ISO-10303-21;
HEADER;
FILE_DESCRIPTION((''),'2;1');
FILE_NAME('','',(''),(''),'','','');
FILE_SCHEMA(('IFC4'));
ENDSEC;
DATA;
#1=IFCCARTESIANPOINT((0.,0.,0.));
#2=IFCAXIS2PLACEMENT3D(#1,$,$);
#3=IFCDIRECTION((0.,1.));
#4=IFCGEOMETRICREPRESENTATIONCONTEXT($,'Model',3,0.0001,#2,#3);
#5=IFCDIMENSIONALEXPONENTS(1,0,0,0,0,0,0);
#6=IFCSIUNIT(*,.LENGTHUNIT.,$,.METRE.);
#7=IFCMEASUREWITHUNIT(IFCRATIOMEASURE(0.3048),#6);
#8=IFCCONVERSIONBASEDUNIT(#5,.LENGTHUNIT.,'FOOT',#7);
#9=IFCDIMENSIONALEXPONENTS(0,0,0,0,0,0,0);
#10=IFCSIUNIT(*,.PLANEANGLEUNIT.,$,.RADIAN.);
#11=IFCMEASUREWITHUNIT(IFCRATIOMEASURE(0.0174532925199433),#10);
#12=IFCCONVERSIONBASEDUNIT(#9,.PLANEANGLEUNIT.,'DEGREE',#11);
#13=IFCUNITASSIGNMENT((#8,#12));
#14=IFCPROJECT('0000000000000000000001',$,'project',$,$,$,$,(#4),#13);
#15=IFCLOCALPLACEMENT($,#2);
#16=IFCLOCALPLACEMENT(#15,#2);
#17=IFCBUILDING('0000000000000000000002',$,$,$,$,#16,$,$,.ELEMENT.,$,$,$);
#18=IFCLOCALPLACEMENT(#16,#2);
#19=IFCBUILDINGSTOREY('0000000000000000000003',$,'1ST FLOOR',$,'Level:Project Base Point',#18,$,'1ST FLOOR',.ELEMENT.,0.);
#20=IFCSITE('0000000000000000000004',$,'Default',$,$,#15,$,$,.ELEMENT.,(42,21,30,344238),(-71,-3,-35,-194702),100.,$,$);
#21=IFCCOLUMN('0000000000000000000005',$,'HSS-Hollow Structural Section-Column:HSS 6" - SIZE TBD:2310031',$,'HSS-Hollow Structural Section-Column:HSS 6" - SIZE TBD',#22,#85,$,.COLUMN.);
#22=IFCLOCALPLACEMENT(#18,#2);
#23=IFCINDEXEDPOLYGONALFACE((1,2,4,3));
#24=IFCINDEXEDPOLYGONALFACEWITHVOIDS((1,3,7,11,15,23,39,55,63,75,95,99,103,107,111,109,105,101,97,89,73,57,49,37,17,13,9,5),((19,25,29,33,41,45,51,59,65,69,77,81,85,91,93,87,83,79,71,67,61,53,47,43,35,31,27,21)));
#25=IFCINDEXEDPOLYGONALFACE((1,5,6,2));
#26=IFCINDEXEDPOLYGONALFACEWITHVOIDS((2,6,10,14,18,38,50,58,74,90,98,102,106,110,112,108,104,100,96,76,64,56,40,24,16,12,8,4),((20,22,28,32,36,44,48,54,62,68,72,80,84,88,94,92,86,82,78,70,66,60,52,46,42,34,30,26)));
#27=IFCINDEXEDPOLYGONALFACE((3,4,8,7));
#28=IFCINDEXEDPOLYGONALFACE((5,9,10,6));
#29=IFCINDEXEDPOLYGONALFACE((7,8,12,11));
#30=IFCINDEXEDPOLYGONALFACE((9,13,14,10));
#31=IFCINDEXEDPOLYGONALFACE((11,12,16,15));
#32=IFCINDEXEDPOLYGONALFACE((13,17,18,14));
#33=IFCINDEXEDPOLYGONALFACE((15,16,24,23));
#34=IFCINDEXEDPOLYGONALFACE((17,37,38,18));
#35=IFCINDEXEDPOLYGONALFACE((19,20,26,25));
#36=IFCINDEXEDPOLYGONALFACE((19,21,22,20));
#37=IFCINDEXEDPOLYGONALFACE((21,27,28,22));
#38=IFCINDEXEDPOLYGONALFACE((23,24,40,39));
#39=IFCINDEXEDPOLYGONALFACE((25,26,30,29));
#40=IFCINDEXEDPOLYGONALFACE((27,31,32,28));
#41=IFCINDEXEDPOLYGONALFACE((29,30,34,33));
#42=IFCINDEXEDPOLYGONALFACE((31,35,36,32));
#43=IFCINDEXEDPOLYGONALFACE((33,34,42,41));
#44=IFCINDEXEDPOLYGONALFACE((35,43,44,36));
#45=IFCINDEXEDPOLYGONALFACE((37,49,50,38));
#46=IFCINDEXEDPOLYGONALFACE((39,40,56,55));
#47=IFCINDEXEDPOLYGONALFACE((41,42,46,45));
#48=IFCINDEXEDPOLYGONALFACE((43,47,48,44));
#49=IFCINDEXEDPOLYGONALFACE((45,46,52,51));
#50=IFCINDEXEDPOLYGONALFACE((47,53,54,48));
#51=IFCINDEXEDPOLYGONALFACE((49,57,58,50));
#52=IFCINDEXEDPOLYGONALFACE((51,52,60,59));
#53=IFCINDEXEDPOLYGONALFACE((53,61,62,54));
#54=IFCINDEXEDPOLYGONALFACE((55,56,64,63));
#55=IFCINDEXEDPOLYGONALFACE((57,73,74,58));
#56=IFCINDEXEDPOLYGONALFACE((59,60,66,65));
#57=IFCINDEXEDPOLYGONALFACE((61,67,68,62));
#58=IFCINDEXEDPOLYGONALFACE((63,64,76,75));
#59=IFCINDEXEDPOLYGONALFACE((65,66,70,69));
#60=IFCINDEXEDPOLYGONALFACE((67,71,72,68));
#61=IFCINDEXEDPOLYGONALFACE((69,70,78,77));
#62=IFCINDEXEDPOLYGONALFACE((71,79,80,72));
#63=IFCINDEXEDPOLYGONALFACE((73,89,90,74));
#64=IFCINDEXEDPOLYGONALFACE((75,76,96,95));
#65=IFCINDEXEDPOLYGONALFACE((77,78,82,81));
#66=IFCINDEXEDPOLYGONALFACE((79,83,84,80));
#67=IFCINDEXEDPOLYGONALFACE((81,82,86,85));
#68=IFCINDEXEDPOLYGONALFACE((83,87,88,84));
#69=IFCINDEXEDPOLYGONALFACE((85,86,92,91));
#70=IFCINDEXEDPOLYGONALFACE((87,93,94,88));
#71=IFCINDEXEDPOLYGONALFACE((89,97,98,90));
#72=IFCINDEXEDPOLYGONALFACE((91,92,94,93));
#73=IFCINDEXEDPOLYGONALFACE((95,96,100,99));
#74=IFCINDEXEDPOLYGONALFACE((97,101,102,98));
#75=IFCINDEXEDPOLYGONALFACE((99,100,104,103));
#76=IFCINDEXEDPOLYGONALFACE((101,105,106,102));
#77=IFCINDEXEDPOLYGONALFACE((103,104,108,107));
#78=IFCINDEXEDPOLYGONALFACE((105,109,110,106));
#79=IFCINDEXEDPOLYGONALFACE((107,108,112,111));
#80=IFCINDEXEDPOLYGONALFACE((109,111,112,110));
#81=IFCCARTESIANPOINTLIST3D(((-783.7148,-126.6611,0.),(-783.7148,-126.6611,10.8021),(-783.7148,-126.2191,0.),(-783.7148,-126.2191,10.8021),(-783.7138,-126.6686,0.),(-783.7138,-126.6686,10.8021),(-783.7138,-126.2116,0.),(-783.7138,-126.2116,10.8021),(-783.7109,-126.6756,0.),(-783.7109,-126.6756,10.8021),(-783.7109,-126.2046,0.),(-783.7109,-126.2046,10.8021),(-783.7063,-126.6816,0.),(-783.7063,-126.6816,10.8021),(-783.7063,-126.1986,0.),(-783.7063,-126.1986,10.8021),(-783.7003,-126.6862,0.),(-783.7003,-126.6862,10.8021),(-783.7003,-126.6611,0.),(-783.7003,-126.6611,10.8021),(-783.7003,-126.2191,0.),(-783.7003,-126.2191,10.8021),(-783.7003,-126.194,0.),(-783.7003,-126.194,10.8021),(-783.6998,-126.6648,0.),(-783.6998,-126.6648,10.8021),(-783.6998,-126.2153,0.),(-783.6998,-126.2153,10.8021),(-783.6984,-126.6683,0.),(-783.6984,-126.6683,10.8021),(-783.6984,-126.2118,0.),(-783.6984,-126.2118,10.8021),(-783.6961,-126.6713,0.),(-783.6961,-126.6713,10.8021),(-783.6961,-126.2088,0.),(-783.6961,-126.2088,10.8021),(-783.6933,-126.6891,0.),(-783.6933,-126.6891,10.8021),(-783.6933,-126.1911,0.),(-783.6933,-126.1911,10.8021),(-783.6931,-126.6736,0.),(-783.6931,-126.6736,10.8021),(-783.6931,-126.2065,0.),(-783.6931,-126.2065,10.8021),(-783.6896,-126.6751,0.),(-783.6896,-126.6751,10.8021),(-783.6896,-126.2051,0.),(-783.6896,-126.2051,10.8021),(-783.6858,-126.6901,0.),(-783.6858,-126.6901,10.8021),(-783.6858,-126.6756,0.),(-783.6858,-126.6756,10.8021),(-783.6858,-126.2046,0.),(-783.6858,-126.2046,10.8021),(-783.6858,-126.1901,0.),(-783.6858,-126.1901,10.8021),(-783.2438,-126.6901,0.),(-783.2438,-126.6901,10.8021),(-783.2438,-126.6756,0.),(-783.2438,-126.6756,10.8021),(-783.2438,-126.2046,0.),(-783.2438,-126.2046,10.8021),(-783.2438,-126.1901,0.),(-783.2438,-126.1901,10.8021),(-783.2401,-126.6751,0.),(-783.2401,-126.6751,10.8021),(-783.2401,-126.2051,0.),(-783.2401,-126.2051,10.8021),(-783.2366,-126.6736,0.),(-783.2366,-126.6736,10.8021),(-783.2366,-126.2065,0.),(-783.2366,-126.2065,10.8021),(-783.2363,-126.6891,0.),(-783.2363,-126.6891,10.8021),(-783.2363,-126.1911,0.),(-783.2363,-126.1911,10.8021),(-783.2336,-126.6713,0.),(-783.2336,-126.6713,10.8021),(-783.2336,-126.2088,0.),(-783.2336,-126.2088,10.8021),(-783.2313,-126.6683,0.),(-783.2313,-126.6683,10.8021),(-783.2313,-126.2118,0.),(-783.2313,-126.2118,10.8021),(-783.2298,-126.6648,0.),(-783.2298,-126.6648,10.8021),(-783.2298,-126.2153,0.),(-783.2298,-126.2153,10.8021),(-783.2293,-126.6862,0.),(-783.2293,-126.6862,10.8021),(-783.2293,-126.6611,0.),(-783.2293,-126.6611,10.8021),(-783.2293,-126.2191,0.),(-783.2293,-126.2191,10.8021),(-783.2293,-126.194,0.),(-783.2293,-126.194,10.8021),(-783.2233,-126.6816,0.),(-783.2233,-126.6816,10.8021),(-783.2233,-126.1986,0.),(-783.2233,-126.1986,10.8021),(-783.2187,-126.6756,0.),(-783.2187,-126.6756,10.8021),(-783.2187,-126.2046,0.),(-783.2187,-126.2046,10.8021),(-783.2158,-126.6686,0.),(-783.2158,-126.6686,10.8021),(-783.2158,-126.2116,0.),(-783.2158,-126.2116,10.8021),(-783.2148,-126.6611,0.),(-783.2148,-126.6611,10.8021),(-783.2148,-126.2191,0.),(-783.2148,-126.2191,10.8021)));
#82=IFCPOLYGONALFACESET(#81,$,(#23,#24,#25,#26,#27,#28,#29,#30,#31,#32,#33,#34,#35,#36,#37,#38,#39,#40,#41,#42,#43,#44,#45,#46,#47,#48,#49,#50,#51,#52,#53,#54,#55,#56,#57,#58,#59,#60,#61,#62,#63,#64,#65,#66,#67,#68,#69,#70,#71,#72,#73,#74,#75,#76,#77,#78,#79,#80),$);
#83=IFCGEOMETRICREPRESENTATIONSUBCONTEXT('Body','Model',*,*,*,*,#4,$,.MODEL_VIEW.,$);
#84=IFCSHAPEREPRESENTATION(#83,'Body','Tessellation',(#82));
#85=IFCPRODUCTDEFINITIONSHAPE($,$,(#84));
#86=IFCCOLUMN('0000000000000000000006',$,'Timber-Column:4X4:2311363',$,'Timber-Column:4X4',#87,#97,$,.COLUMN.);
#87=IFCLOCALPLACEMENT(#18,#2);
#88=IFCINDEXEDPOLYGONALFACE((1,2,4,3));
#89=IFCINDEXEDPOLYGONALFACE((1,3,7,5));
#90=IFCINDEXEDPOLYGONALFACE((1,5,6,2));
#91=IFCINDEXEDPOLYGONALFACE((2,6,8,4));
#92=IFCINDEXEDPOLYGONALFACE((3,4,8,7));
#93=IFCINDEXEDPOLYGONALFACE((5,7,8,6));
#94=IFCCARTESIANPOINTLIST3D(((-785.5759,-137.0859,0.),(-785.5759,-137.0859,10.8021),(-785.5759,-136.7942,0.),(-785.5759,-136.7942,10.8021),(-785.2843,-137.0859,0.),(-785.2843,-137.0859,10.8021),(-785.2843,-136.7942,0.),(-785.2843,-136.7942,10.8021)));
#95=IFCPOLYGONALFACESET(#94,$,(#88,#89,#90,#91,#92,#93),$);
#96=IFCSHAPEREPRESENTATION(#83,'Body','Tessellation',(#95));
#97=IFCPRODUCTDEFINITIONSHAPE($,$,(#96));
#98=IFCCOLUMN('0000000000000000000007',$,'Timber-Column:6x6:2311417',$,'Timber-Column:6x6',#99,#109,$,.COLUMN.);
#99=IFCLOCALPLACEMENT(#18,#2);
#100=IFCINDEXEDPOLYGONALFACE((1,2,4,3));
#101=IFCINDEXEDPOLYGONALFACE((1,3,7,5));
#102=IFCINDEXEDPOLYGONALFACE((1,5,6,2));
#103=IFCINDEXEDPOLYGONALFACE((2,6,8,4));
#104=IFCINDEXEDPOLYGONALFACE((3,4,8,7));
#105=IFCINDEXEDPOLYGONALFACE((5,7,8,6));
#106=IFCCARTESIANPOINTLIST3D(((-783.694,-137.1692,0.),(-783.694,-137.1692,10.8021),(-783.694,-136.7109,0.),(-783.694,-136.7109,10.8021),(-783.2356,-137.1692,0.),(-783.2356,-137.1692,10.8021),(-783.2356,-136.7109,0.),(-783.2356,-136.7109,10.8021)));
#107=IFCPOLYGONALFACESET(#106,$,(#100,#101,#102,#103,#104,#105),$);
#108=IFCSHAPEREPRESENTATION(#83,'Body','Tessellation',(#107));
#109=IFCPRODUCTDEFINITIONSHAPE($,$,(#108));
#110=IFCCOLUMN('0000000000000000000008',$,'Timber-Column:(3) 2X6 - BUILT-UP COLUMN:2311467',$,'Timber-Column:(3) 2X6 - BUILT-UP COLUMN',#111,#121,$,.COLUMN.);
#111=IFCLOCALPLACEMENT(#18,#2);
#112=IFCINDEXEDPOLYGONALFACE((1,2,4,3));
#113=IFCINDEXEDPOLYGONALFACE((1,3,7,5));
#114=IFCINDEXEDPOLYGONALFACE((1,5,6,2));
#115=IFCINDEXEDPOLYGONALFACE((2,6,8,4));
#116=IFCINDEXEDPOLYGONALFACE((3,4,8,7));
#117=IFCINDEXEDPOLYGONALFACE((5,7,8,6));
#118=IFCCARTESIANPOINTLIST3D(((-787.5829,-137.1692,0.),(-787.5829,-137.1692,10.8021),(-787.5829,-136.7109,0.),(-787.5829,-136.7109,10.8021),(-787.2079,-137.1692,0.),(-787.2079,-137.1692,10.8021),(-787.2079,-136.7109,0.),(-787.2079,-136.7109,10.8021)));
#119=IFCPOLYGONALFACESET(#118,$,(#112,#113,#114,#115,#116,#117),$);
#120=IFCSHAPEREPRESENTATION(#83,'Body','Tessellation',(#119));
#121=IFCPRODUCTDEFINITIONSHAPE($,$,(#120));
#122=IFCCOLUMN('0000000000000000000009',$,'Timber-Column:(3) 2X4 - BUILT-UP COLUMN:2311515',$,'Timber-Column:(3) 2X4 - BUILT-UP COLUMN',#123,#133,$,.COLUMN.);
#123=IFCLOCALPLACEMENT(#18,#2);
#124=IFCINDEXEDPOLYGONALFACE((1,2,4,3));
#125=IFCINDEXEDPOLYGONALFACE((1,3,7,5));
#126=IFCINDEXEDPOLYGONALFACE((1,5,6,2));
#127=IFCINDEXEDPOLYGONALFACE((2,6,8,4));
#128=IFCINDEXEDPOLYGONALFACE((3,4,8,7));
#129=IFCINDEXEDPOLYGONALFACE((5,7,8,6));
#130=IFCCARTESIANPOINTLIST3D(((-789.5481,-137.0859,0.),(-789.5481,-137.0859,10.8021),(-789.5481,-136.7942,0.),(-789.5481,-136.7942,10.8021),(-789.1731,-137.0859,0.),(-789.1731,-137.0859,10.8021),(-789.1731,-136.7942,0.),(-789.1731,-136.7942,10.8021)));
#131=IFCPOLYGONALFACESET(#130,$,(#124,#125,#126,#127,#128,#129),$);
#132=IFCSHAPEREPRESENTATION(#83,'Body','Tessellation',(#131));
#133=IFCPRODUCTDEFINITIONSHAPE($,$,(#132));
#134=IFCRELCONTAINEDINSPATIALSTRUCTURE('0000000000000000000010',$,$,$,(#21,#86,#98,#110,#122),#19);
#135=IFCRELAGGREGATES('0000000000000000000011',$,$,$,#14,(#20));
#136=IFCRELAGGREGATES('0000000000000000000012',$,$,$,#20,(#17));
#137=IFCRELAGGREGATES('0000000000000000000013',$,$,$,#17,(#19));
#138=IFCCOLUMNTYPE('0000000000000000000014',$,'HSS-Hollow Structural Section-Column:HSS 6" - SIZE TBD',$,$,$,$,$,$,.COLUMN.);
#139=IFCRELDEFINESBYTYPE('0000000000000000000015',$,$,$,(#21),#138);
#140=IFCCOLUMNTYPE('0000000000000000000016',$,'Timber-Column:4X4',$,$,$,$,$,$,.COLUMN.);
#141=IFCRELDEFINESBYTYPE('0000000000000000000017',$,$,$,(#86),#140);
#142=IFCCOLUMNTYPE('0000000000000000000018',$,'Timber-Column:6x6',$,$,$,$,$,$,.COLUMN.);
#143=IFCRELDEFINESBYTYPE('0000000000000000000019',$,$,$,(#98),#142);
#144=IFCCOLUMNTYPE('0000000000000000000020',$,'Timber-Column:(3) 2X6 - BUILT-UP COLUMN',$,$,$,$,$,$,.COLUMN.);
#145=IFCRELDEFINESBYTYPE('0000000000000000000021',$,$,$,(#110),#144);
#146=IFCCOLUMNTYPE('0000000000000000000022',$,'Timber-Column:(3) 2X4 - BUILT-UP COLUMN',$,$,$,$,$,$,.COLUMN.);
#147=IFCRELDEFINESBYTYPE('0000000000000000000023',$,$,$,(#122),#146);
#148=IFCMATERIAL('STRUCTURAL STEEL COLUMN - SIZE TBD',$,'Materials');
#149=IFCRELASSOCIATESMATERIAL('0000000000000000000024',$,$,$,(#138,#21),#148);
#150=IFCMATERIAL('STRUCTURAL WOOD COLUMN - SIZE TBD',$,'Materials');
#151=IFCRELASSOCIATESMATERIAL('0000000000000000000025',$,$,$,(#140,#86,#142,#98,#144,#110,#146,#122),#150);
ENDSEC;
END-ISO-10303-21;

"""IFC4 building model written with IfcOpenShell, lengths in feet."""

from ifc_helpers import new_model, entity, si_unit, converted_unit, direction, frame, frame_2d, origin, origin_2d_with_axis, place, context, subcontext, project, spatial, polyline, circle_curve, parameter, trimmed, segment, composite_curve, rectangle, outline, extrude, source, transform, mapped, material, material_profile, profile_set, profile_usage, type_object, type_shapes, element, save


model = new_model("IFC4")

# Units and contexts
model_context = context("Model", 3, precision=0.0001, world=origin(), true_north=direction((0.0, 1.0)))
body_context = subcontext(model_context, "Body", "Model", "MODEL_VIEW")
ifc_project = project(units=[converted_unit("LENGTHUNIT", "FOOT", entity("IfcRatioMeasure", 0.3048), si_unit("LENGTHUNIT", "METRE"), dimensions=[1, 0, 0, 0, 0, 0, 0]), converted_unit("PLANEANGLEUNIT", "DEGREE", entity("IfcRatioMeasure", 0.0174532925199433), si_unit("PLANEANGLEUNIT", "RADIAN"), dimensions=[0, 0, 0, 0, 0, 0, 0])], contexts=[model_context])

# Site, building, storey
site_placement = place(None, origin())
site = spatial("IfcSite", under=ifc_project, at=site_placement, Name="Default", CompositionType="ELEMENT", RefLatitude=(42, 21, 30, 344238), RefLongitude=(-71, -3, -35, -194702), RefElevation=100.0)
building_placement = place(site_placement, origin())
building = spatial("IfcBuilding", under=site, at=building_placement, CompositionType="ELEMENT")
storey_placement = place(building_placement, origin())
storey = spatial("IfcBuildingStorey", under=building, at=storey_placement, Name="1ST FLOOR", ObjectType="Level:Project Base Point", LongName="1ST FLOOR", CompositionType="ELEMENT", Elevation=0.0)

# Columns
ifc_material_1 = material(Name="STRUCTURAL STEEL COLUMN - SIZE TBD", Category="Materials")
ifc_material_profile_1 = material_profile(ifc_material_1, outline(composite_curve([segment(polyline([(-0.221, -0.25), (0.221, -0.25)]), True, "CONTINUOUS"), segment(trimmed(circle_curve(frame_2d((0.221, -0.221), x_axis=(-1.0, 0.0)), 0.029), [parameter(90.0)], [parameter(180.0)], True, "PARAMETER"), True, "CONTINUOUS"), segment(polyline([(0.25, -0.221), (0.25, 0.221)]), True, "CONTINUOUS"), segment(trimmed(circle_curve(frame_2d((0.221, 0.221), x_axis=(-1.0, 0.0)), 0.029), [parameter(180.0)], [parameter(270.0)], True, "PARAMETER"), True, "CONTINUOUS"), segment(polyline([(0.221, 0.25), (-0.221, 0.25)]), True, "CONTINUOUS"), segment(trimmed(circle_curve(frame_2d((-0.221, 0.221), x_axis=(-1.0, 0.0)), 0.029), [parameter(270.0)], [parameter(360.0)], True, "PARAMETER"), True, "CONTINUOUS"), segment(polyline([(-0.25, 0.221), (-0.25, -0.221)]), True, "CONTINUOUS"), segment(trimmed(circle_curve(frame_2d((-0.221, -0.221), x_axis=(-1.0, 0.0)), 0.029), [parameter(360.0)], [parameter(90.0)], True, "PARAMETER"), True, "CONTINUOUS")], self_intersect=False), holes=[composite_curve([segment(trimmed(circle_curve(frame_2d((-0.221, -0.221), x_axis=(-1.0, 0.0)), 0.0145), [parameter(0.0)], [parameter(90.0)], True, "PARAMETER"), False, "CONTINUOUS"), segment(polyline([(-0.2355, -0.221), (-0.2355, 0.221)]), True, "CONTINUOUS"), segment(trimmed(circle_curve(frame_2d((-0.221, 0.221), x_axis=(-1.0, 0.0)), 0.0145), [parameter(270.0)], [parameter(360.0)], True, "PARAMETER"), False, "CONTINUOUS"), segment(polyline([(-0.221, 0.2355), (0.221, 0.2355)]), True, "CONTINUOUS"), segment(trimmed(circle_curve(frame_2d((0.221, 0.221), x_axis=(-1.0, 0.0)), 0.0145), [parameter(180.0)], [parameter(270.0)], True, "PARAMETER"), False, "CONTINUOUS"), segment(polyline([(0.2355, 0.221), (0.2355, -0.221)]), True, "CONTINUOUS"), segment(trimmed(circle_curve(frame_2d((0.221, -0.221), x_axis=(-1.0, 0.0)), 0.0145), [parameter(90.0)], [parameter(180.0)], True, "PARAMETER"), False, "CONTINUOUS"), segment(polyline([(0.221, -0.2355), (-0.221, -0.2355)]), True, "CONTINUOUS")], self_intersect=False)]), Name="HSS 6\" - SIZE TBD")
ifc_profile_set_1 = profile_set([ifc_material_profile_1], Name="HSS 6\" - SIZE TBD")
ifc_profile_usage_1 = profile_usage(ifc_profile_set_1)
column_type_1 = type_object("IfcColumnType", Name="HSS-Hollow Structural Section-Column:HSS 6\" - SIZE TBD", PredefinedType="COLUMN", material=ifc_profile_set_1)
shared_shape_1 = source(origin(), body_context, "Body", "SweptSolid", [
    extrude(outline(composite_curve([segment(polyline([(-0.221, -0.25), (0.221, -0.25)]), True, "CONTINUOUS"), segment(trimmed(circle_curve(frame_2d((0.221, -0.221), x_axis=(-1.0, 0.0)), 0.029), [parameter(90.0)], [parameter(180.0)], True, "PARAMETER"), True, "CONTINUOUS"), segment(polyline([(0.25, -0.221), (0.25, 0.221)]), True, "CONTINUOUS"), segment(trimmed(circle_curve(frame_2d((0.221, 0.221), x_axis=(-1.0, 0.0)), 0.029), [parameter(180.0)], [parameter(270.0)], True, "PARAMETER"), True, "CONTINUOUS"), segment(polyline([(0.221, 0.25), (-0.221, 0.25)]), True, "CONTINUOUS"), segment(trimmed(circle_curve(frame_2d((-0.221, 0.221), x_axis=(-1.0, 0.0)), 0.029), [parameter(270.0)], [parameter(360.0)], True, "PARAMETER"), True, "CONTINUOUS"), segment(polyline([(-0.25, 0.221), (-0.25, -0.221)]), True, "CONTINUOUS"), segment(trimmed(circle_curve(frame_2d((-0.221, -0.221), x_axis=(-1.0, 0.0)), 0.029), [parameter(360.0)], [parameter(90.0)], True, "PARAMETER"), True, "CONTINUOUS")], self_intersect=False), holes=[composite_curve([segment(trimmed(circle_curve(frame_2d((-0.221, -0.221), x_axis=(-1.0, 0.0)), 0.0145), [parameter(0.0)], [parameter(90.0)], True, "PARAMETER"), False, "CONTINUOUS"), segment(polyline([(-0.2355, -0.221), (-0.2355, 0.221)]), True, "CONTINUOUS"), segment(trimmed(circle_curve(frame_2d((-0.221, 0.221), x_axis=(-1.0, 0.0)), 0.0145), [parameter(270.0)], [parameter(360.0)], True, "PARAMETER"), False, "CONTINUOUS"), segment(polyline([(-0.221, 0.2355), (0.221, 0.2355)]), True, "CONTINUOUS"), segment(trimmed(circle_curve(frame_2d((0.221, 0.221), x_axis=(-1.0, 0.0)), 0.0145), [parameter(180.0)], [parameter(270.0)], True, "PARAMETER"), False, "CONTINUOUS"), segment(polyline([(0.2355, 0.221), (0.2355, -0.221)]), True, "CONTINUOUS"), segment(trimmed(circle_curve(frame_2d((0.221, -0.221), x_axis=(-1.0, 0.0)), 0.0145), [parameter(90.0)], [parameter(180.0)], True, "PARAMETER"), False, "CONTINUOUS"), segment(polyline([(0.221, -0.2355), (-0.221, -0.2355)]), True, "CONTINUOUS")], self_intersect=False)]), frame((0.0, 0.0, 0.0), z_axis=(0.0, 0.0, 1.0), x_axis=(-1.0, 0.0, 0.0)), (0.0, 0.0, 1.0), 10.8021),
])
type_shapes(column_type_1, [shared_shape_1])
column_1_placement = place(storey_placement, frame((-783.4648, -126.4401, 0.0)))
element("IfcColumn", 1, at=column_1_placement, inside=storey, type_object=column_type_1, material=ifc_profile_usage_1, Name="HSS-Hollow Structural Section-Column:HSS 6\" - SIZE TBD:2310031", ObjectType="HSS-Hollow Structural Section-Column:HSS 6\" - SIZE TBD", PredefinedType="COLUMN", context=body_context, shape_type="MappedRepresentation", body=[
    mapped(shared_shape_1, transform((0.0, 0.0, 0.0), scale=1.0)),
])
ifc_material_2 = material(Name="STRUCTURAL WOOD COLUMN - SIZE TBD", Category="Materials")
ifc_material_profile_2 = material_profile(ifc_material_2, rectangle(XDim=0.2917, YDim=0.2917, at=origin_2d_with_axis()), Name="4X4")
ifc_profile_set_2 = profile_set([ifc_material_profile_2], Name="4X4")
ifc_profile_usage_2 = profile_usage(ifc_profile_set_2)
column_type_2 = type_object("IfcColumnType", Name="Timber-Column:4X4", PredefinedType="COLUMN", material=ifc_profile_set_2)
shared_shape_2 = source(origin(), body_context, "Body", "SweptSolid", [
    extrude(rectangle(XDim=0.2917, YDim=0.2917, at=origin_2d_with_axis()), frame((0.0, 0.0, 0.0), z_axis=(0.0, 0.0, 1.0), x_axis=(0.0, -1.0, 0.0)), (0.0, 0.0, 1.0), 10.8021),
])
type_shapes(column_type_2, [shared_shape_2])
column_2_placement = place(storey_placement, frame((-785.4301, -136.9401, 0.0)))
element("IfcColumn", 2, at=column_2_placement, inside=storey, type_object=column_type_2, material=ifc_profile_usage_2, Name="Timber-Column:4X4:2311363", ObjectType="Timber-Column:4X4", PredefinedType="COLUMN", context=body_context, shape_type="MappedRepresentation", body=[
    mapped(shared_shape_2, transform((0.0, 0.0, 0.0), scale=1.0)),
])
ifc_material_profile_3 = material_profile(ifc_material_2, rectangle(XDim=0.4583, YDim=0.4583, at=origin_2d_with_axis()), Name="6x6")
ifc_profile_set_3 = profile_set([ifc_material_profile_3], Name="6x6")
ifc_profile_usage_3 = profile_usage(ifc_profile_set_3)
column_type_3 = type_object("IfcColumnType", Name="Timber-Column:6x6", PredefinedType="COLUMN", material=ifc_profile_set_3)
shared_shape_3 = source(origin(), body_context, "Body", "SweptSolid", [
    extrude(rectangle(XDim=0.4583, YDim=0.4583, at=frame_2d((0.0, 0.0), x_axis=(1.0, 0.0))), frame((0.0, 0.0, 0.0), z_axis=(0.0, 0.0, 1.0), x_axis=(0.0, -1.0, 0.0)), (0.0, 0.0, 1.0), 10.8021),
])
type_shapes(column_type_3, [shared_shape_3])
column_3_placement = place(storey_placement, frame((-783.4648, -136.9401, 0.0)))
element("IfcColumn", 3, at=column_3_placement, inside=storey, type_object=column_type_3, material=ifc_profile_usage_3, Name="Timber-Column:6x6:2311417", ObjectType="Timber-Column:6x6", PredefinedType="COLUMN", context=body_context, shape_type="MappedRepresentation", body=[
    mapped(shared_shape_3, transform((0.0, 0.0, 0.0), scale=1.0)),
])
ifc_material_profile_4 = material_profile(ifc_material_2, rectangle(XDim=0.4583, YDim=0.375, at=origin_2d_with_axis()), Name="(3) 2X6 - BUILT-UP COLUMN")
ifc_profile_set_4 = profile_set([ifc_material_profile_4], Name="(3) 2X6 - BUILT-UP COLUMN")
ifc_profile_usage_4 = profile_usage(ifc_profile_set_4)
column_type_4 = type_object("IfcColumnType", Name="Timber-Column:(3) 2X6 - BUILT-UP COLUMN", PredefinedType="COLUMN", material=ifc_profile_set_4)
shared_shape_4 = source(origin(), body_context, "Body", "SweptSolid", [
    extrude(rectangle(XDim=0.4583, YDim=0.375, at=origin_2d_with_axis()), frame((0.0, 0.0, 0.0), z_axis=(0.0, 0.0, 1.0), x_axis=(0.0, -1.0, 0.0)), (0.0, 0.0, 1.0), 10.8021),
])
type_shapes(column_type_4, [shared_shape_4])
column_4_placement = place(storey_placement, frame((-787.3954, -136.9401, 0.0)))
element("IfcColumn", 4, at=column_4_placement, inside=storey, type_object=column_type_4, material=ifc_profile_usage_4, Name="Timber-Column:(3) 2X6 - BUILT-UP COLUMN:2311467", ObjectType="Timber-Column:(3) 2X6 - BUILT-UP COLUMN", PredefinedType="COLUMN", context=body_context, shape_type="MappedRepresentation", body=[
    mapped(shared_shape_4, transform((0.0, 0.0, 0.0), scale=1.0)),
])
ifc_material_profile_5 = material_profile(ifc_material_2, rectangle(XDim=0.2917, YDim=0.375, at=origin_2d_with_axis()), Name="(3) 2X4 - BUILT-UP COLUMN")
ifc_profile_set_5 = profile_set([ifc_material_profile_5], Name="(3) 2X4 - BUILT-UP COLUMN")
ifc_profile_usage_5 = profile_usage(ifc_profile_set_5)
column_type_5 = type_object("IfcColumnType", Name="Timber-Column:(3) 2X4 - BUILT-UP COLUMN", PredefinedType="COLUMN", material=ifc_profile_set_5)
shared_shape_5 = source(origin(), body_context, "Body", "SweptSolid", [
    extrude(rectangle(XDim=0.2917, YDim=0.375, at=origin_2d_with_axis()), frame((0.0, 0.0, 0.0), z_axis=(0.0, 0.0, 1.0), x_axis=(0.0, -1.0, 0.0)), (0.0, 0.0, 1.0), 10.8021),
])
type_shapes(column_type_5, [shared_shape_5])
column_5_placement = place(storey_placement, frame((-789.3606, -136.9401, 0.0)))
element("IfcColumn", 5, at=column_5_placement, inside=storey, type_object=column_type_5, material=ifc_profile_usage_5, Name="Timber-Column:(3) 2X4 - BUILT-UP COLUMN:2311515", ObjectType="Timber-Column:(3) 2X4 - BUILT-UP COLUMN", PredefinedType="COLUMN", context=body_context, shape_type="MappedRepresentation", body=[
    mapped(shared_shape_5, transform((0.0, 0.0, 0.0), scale=1.0)),
])

save(model, "model.ifc")
